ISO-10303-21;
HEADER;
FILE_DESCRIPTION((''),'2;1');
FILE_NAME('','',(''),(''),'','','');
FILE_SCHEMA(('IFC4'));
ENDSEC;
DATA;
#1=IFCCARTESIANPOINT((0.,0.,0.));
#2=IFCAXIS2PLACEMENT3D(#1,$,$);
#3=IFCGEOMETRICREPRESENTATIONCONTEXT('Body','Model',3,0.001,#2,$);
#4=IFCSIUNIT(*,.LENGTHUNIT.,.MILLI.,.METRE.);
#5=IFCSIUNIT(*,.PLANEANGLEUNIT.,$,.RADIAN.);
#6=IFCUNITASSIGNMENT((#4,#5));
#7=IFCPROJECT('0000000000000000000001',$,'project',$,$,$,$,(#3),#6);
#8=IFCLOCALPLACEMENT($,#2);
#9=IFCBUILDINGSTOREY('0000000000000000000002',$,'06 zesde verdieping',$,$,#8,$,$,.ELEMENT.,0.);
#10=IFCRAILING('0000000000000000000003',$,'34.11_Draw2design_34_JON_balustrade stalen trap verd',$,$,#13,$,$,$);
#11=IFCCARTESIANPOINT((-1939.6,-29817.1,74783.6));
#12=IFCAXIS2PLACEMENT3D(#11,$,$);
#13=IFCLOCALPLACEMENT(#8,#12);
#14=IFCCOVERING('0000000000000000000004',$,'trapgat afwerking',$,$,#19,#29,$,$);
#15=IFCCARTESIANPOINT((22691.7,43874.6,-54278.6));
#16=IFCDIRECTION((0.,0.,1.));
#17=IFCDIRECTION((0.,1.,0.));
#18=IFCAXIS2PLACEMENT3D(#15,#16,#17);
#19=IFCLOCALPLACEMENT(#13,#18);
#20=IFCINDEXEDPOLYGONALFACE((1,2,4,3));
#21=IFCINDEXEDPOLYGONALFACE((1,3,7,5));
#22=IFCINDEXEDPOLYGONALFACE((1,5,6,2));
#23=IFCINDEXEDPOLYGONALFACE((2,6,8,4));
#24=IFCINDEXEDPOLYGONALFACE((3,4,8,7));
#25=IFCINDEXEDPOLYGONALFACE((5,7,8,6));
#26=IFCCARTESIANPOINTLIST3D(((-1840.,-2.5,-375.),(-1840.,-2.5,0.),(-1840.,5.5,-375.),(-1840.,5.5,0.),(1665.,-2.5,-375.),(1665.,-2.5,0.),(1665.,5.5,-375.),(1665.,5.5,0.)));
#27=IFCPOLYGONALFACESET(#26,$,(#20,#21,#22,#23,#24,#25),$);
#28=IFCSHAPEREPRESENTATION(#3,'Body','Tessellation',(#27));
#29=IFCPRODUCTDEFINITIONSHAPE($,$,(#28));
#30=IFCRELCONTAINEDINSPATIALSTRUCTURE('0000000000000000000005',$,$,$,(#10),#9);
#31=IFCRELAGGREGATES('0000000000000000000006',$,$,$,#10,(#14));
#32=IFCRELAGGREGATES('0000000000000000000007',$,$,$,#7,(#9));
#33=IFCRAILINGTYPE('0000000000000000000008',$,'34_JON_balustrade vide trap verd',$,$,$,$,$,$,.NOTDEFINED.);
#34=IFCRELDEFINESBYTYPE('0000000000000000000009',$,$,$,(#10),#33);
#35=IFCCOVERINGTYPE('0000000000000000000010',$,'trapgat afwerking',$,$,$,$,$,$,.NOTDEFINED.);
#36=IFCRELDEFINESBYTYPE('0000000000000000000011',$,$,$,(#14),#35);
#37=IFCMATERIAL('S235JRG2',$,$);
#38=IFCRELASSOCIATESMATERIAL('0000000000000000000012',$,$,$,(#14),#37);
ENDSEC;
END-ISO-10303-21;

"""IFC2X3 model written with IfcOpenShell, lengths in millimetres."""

from ifc_helpers import new_model, si_unit, frame, origin, place, context, project, spatial, polyline, outline, extrude, source, transform, mapped, material, type_object, element, aggregate, save


model = new_model("IFC2X3")

# Units and contexts
model_context = context("Model", 3, precision=0.001, world=origin(), identifier="Body")
ifc_project = project(units=[si_unit("LENGTHUNIT", "METRE", prefix="MILLI"), si_unit("PLANEANGLEUNIT", "RADIAN")], contexts=[model_context])

# Storey
storey_placement = place(None, origin())
storey = spatial("IfcBuildingStorey", under=ifc_project, at=storey_placement, Name="06 zesde verdieping", CompositionType="ELEMENT", Elevation=0.0)

# Railing, covering
railing_type = type_object("IfcRailingType", Name="34_JON_balustrade vide trap verd")
railing_placement = place(storey_placement, frame((-1939.6, -29817.1, 74783.6)))
railing = element("IfcRailing", 1, at=railing_placement, inside=storey, type_object=railing_type, Name="34.11_Draw2design_34_JON_balustrade stalen trap verd")
ifc_material_1 = material(Name="S235JRG2")
covering_type = type_object("IfcCoveringType", Name="trapgat afwerking")
shared_shape_1 = source(origin(), model_context, "Body", "SweptSolid", [
    extrude(outline(polyline([(-1840.0, -2.5), (1665.0, -2.5), (1665.0, 5.5), (-1840.0, 5.5), (-1840.0, -2.5)])), origin(), (0.0, 0.0, -1.0), 375.0),
])
covering_placement = place(railing_placement, frame((22691.7, 43874.6, -54278.6), z_axis=(0.0, 0.0, 1.0), x_axis=(0.0, 1.0, 0.0)))
covering = element("IfcCovering", 2, at=covering_placement, type_object=covering_type, material=ifc_material_1, Name="trapgat afwerking", context=model_context, shape_type="MappedRepresentation", body=[
    mapped(shared_shape_1, transform((0.0, 0.0, 0.0), scale=1.0)),
])
aggregate(railing, [covering])

save(model, "model.ifc")
